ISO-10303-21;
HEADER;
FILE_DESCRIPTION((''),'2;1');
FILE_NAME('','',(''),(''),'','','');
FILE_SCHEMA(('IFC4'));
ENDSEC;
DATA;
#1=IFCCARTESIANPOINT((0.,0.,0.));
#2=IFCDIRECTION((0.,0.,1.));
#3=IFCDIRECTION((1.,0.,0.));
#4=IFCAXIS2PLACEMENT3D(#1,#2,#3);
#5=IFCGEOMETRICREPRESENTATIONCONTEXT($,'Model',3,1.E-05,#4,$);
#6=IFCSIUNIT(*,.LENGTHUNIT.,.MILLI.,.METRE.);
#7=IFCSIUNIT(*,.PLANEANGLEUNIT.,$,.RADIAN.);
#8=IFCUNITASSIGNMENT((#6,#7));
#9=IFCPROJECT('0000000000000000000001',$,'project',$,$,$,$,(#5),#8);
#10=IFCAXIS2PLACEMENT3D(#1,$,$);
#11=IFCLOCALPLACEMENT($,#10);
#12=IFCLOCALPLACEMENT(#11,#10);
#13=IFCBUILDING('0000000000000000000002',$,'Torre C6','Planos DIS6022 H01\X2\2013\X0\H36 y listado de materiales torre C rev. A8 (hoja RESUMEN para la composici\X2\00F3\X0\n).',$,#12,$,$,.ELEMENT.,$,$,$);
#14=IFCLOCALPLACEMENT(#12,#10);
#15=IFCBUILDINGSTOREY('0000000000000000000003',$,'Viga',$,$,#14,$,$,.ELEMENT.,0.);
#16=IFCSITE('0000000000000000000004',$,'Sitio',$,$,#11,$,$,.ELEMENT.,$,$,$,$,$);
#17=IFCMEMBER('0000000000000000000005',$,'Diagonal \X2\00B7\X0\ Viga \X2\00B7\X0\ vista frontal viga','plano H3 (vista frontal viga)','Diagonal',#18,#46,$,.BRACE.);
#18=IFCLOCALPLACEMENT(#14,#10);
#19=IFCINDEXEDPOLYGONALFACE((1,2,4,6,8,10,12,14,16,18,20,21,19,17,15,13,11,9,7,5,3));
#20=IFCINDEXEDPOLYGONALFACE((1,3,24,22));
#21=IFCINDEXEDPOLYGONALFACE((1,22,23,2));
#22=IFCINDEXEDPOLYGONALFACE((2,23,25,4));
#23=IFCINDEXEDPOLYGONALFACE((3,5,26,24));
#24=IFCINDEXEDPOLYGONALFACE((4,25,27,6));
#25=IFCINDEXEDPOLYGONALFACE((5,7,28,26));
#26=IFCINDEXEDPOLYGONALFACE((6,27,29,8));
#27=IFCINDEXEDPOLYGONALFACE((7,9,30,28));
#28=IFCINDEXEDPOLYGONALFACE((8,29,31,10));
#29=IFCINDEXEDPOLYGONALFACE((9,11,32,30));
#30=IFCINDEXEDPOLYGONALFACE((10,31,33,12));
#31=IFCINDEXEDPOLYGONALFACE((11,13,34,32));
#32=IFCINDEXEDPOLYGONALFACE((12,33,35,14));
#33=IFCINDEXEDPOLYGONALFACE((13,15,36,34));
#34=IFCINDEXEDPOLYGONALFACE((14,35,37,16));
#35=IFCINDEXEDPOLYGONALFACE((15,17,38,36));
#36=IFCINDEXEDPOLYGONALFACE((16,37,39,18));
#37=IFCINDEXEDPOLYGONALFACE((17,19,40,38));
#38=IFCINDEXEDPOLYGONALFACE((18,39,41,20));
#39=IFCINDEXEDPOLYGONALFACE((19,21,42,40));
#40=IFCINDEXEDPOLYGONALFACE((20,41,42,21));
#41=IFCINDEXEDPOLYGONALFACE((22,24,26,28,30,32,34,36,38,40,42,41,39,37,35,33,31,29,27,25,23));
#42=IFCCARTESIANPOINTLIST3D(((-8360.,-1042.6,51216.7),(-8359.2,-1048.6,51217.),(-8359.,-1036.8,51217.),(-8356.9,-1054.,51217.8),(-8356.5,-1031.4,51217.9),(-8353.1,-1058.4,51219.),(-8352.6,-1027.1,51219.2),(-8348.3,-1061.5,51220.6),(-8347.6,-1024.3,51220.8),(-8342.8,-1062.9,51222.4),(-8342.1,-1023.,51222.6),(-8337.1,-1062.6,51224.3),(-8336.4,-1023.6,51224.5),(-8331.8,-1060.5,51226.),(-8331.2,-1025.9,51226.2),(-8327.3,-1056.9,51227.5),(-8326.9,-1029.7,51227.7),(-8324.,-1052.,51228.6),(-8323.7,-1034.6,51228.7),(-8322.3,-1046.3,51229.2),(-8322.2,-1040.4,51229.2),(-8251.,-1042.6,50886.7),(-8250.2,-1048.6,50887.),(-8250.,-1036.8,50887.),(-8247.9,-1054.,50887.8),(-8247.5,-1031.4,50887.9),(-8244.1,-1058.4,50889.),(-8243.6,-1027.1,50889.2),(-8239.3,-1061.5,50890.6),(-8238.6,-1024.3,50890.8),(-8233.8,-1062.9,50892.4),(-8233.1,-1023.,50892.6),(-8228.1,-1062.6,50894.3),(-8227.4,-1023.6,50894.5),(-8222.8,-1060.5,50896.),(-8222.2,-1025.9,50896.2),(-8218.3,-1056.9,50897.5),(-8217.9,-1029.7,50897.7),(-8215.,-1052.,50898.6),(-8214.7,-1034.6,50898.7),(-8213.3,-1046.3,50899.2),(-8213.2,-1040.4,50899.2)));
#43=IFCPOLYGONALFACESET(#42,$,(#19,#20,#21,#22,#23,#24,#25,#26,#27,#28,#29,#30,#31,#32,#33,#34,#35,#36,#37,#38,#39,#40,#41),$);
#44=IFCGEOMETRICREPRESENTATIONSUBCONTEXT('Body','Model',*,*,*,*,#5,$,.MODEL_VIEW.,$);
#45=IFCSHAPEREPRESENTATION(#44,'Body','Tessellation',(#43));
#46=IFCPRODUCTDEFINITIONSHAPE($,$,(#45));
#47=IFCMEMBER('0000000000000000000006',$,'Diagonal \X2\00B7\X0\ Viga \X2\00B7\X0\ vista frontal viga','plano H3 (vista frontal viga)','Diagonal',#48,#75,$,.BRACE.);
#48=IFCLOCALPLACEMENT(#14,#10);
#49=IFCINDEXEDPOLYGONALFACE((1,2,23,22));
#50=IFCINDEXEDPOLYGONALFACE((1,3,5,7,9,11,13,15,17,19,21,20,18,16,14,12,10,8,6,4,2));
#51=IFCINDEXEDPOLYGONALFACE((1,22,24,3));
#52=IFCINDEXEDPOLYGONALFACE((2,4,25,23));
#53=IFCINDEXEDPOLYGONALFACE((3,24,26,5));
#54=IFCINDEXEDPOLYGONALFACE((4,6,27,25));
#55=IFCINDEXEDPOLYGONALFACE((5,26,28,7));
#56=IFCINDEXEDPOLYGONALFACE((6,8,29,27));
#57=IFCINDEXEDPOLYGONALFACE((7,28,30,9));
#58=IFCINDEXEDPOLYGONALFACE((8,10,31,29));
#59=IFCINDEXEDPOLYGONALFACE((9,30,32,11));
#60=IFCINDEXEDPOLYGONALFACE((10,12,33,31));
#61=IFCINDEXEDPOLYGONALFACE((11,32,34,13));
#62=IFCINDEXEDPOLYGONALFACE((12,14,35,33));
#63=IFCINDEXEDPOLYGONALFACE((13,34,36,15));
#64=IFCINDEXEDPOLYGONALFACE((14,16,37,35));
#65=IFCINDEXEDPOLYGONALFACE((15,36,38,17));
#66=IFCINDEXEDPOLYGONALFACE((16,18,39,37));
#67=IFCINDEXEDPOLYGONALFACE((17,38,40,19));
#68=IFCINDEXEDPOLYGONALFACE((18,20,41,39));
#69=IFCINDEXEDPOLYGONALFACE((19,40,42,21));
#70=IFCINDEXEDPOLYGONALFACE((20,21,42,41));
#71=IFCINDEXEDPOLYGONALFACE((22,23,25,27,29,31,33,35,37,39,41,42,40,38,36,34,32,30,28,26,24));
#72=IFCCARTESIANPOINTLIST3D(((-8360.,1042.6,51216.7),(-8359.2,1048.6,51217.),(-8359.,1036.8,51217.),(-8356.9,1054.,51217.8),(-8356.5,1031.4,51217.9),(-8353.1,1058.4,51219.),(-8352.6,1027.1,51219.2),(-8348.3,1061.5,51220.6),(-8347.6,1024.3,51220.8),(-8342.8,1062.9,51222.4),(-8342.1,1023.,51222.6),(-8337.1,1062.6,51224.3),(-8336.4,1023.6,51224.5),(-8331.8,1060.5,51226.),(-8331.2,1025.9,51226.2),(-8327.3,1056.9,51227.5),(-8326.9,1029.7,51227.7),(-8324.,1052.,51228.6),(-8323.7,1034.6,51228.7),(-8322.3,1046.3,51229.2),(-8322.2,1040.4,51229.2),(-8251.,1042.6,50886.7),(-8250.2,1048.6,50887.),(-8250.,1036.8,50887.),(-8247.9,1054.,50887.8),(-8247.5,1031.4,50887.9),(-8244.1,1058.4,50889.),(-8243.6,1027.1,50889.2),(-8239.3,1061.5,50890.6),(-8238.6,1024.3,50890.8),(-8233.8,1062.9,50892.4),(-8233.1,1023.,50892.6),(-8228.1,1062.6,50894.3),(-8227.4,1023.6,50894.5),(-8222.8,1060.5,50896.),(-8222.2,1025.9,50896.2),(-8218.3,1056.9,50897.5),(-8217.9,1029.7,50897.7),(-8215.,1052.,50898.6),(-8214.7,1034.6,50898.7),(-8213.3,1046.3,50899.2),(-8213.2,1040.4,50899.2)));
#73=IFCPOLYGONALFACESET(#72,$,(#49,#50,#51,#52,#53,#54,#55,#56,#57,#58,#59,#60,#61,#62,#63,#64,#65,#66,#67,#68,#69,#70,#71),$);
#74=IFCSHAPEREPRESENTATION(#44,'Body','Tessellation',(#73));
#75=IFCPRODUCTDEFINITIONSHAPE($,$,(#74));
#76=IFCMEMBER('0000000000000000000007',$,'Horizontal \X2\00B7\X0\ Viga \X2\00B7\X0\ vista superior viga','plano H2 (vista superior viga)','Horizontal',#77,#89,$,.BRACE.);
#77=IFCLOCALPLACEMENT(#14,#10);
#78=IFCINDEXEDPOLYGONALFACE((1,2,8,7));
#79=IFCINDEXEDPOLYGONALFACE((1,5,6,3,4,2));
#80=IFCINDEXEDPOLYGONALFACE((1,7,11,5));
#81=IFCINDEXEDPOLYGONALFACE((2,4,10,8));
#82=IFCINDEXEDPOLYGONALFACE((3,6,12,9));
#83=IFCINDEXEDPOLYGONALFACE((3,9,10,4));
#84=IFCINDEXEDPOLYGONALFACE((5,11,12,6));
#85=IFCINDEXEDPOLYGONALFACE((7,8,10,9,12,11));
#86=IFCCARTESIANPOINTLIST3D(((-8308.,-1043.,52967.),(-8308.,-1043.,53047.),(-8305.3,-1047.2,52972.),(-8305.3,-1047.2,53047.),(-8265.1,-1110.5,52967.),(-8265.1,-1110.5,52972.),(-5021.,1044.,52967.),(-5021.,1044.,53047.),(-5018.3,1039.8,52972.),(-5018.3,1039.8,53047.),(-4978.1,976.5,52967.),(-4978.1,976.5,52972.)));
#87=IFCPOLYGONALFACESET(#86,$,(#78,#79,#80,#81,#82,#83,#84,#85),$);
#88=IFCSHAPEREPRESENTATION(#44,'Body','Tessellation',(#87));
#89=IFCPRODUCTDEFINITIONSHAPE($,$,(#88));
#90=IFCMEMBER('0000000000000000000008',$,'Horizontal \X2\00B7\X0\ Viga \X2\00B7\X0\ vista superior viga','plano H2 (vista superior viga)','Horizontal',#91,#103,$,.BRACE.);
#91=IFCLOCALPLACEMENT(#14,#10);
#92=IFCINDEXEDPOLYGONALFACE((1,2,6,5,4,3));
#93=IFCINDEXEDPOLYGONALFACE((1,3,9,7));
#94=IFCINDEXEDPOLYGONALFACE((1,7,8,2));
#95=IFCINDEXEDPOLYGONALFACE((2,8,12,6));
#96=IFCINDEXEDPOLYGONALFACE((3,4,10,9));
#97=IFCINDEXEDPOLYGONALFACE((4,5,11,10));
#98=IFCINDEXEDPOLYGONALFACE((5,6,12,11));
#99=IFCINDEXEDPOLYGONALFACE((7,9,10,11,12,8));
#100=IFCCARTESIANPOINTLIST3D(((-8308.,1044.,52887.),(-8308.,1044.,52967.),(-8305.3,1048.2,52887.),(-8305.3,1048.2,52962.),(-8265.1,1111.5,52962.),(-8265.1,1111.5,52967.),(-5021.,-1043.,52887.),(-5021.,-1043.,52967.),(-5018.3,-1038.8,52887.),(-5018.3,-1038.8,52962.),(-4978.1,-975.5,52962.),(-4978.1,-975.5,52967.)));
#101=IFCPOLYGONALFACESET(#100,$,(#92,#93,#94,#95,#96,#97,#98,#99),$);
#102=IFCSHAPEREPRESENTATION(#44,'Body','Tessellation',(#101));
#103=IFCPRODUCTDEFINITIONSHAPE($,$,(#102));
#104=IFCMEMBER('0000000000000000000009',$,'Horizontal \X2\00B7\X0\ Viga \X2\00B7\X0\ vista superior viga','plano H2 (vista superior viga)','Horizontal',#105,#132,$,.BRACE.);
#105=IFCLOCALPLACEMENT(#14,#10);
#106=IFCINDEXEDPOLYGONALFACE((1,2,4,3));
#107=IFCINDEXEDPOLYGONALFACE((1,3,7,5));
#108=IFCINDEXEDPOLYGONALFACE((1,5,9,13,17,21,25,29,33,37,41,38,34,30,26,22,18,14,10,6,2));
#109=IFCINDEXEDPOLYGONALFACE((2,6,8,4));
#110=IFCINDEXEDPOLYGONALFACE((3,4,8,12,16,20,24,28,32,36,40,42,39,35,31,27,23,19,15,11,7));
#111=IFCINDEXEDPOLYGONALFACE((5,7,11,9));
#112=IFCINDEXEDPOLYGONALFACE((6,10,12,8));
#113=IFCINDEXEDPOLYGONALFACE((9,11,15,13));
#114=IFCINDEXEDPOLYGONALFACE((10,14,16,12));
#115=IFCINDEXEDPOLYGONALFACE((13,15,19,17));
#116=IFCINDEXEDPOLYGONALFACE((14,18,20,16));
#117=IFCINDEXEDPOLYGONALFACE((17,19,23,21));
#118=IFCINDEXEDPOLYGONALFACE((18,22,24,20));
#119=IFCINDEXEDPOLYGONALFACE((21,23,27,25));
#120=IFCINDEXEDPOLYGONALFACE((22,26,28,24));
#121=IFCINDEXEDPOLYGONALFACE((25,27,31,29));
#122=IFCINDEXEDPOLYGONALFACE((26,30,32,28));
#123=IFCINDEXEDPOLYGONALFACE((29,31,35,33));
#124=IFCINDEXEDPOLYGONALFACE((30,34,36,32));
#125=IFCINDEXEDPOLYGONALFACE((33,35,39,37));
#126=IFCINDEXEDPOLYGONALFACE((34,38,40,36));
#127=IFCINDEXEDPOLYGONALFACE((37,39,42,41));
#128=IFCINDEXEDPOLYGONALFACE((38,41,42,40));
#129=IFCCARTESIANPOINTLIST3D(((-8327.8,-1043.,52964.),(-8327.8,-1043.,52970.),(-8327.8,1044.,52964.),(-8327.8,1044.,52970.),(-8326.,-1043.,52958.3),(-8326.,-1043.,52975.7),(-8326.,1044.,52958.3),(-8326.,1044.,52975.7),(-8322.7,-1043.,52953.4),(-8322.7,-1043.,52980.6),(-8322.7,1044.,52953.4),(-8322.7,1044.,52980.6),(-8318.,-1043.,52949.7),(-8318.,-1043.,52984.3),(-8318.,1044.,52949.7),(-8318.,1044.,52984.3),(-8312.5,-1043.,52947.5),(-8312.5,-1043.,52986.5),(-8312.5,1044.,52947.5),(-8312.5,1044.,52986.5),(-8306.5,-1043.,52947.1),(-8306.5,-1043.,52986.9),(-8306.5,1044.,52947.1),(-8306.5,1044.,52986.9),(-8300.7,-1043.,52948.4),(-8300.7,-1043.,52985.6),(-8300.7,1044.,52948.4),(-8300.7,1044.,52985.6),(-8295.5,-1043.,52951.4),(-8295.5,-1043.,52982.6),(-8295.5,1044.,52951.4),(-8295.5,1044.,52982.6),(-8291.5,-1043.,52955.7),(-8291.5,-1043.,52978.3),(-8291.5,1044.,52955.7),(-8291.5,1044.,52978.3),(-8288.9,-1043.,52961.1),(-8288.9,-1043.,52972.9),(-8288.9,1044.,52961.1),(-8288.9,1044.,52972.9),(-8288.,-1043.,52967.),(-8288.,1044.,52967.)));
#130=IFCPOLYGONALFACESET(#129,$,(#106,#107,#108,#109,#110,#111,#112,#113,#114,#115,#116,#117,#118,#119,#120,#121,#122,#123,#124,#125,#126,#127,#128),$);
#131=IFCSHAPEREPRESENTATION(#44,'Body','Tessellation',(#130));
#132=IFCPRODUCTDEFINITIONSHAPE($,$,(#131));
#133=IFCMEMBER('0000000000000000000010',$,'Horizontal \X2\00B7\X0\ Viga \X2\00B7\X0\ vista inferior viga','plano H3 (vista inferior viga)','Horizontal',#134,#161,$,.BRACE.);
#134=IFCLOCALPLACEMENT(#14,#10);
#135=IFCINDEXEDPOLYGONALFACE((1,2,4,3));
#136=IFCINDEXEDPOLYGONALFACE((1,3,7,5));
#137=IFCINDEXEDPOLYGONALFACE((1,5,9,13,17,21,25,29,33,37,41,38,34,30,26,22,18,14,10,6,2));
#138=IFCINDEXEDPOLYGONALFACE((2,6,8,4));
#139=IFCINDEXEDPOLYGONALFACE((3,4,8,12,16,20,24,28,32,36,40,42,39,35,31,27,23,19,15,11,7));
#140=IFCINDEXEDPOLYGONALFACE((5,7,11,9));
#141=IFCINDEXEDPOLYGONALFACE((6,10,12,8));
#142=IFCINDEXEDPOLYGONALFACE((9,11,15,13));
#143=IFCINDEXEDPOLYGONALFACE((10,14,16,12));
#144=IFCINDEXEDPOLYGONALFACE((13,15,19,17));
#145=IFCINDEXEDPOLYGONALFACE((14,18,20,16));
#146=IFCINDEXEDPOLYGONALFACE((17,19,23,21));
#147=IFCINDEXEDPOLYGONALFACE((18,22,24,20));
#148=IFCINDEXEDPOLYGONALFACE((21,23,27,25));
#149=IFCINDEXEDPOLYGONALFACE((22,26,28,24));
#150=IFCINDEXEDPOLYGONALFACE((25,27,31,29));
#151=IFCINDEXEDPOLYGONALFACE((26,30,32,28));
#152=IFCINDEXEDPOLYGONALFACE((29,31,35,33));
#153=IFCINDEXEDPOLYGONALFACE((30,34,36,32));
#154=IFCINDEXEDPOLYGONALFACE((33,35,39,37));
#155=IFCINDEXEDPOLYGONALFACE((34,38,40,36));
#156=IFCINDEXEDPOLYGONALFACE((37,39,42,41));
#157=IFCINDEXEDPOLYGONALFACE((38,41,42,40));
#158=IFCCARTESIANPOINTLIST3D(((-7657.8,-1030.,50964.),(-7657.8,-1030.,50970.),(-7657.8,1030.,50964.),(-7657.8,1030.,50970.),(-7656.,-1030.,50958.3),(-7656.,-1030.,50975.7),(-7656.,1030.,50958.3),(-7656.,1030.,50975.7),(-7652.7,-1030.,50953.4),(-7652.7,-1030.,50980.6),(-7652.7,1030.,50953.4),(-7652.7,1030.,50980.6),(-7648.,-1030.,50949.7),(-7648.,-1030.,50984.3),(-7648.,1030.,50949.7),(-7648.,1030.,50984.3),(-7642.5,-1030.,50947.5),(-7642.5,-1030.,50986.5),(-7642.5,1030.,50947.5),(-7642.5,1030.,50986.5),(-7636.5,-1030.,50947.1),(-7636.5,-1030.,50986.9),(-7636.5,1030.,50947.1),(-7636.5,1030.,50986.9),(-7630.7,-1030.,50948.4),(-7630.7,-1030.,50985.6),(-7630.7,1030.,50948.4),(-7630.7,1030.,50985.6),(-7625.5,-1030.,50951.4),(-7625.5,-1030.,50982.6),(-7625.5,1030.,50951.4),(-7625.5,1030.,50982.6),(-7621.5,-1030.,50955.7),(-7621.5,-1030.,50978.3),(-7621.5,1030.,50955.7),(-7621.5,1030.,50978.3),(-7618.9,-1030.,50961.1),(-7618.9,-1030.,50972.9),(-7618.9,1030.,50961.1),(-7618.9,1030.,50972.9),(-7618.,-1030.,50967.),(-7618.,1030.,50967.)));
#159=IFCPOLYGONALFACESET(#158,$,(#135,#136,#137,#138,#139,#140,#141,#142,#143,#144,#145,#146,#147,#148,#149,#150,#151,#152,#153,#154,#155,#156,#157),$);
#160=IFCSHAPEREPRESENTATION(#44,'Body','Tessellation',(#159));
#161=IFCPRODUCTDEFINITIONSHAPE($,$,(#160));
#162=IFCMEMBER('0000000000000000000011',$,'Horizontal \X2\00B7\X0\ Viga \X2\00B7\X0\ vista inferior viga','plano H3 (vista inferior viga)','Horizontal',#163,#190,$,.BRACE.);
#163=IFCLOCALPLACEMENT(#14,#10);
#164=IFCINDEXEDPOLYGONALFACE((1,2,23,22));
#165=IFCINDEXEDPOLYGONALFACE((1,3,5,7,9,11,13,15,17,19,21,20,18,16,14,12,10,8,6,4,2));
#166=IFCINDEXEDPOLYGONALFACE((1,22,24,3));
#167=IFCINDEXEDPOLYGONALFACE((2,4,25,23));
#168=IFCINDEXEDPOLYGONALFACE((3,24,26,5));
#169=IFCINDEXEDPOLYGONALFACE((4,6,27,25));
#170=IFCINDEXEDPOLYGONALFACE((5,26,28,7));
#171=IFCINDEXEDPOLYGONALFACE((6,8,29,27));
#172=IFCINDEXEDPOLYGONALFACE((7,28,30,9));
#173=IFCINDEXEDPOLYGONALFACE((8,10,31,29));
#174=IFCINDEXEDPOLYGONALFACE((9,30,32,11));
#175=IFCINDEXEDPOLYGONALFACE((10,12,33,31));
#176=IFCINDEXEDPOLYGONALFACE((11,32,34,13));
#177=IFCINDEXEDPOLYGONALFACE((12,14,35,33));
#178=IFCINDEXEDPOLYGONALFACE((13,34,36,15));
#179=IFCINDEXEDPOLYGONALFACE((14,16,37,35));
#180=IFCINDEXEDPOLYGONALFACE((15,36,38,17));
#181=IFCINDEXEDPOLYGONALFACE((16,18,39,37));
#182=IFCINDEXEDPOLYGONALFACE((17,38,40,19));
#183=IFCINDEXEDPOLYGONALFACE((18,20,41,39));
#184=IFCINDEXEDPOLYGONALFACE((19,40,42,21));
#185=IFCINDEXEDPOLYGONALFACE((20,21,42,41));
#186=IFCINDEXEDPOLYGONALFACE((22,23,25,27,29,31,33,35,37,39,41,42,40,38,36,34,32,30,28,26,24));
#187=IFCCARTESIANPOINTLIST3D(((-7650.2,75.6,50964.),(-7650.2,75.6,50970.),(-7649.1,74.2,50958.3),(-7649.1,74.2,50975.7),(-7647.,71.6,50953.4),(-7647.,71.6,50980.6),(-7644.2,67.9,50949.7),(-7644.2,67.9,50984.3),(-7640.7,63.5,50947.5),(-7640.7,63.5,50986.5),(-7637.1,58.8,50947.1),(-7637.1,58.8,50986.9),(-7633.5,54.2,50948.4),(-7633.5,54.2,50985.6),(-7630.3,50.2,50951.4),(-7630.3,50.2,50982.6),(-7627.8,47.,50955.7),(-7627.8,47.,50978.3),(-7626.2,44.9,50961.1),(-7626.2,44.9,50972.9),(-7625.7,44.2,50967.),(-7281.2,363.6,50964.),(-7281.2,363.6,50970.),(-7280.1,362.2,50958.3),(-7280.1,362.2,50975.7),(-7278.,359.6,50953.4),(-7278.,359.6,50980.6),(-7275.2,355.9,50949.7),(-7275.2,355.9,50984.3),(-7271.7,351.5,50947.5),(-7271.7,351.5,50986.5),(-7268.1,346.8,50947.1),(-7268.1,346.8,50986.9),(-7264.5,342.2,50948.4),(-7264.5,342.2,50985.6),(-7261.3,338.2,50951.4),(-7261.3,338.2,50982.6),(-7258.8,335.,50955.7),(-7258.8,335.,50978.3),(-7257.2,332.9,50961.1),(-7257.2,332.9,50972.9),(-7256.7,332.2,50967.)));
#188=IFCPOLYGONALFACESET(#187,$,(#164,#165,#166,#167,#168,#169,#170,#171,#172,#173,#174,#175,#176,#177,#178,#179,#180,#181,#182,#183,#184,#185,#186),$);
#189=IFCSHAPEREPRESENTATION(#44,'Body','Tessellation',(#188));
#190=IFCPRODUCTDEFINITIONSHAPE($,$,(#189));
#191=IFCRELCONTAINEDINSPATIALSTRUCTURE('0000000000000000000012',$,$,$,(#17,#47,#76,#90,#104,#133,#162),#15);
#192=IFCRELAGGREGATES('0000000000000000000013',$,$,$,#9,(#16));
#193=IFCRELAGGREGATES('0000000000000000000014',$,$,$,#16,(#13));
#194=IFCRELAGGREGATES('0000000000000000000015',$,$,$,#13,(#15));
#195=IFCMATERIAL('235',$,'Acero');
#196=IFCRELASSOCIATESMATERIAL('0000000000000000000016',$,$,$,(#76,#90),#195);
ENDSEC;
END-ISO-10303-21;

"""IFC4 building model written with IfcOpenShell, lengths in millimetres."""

from ifc_helpers import new_model, si_unit, frame, frame_2d, origin, origin_with_axes, place, context, subcontext, project, spatial, circle, l_section, extrude, material, element, save


model = new_model("IFC4")

# Units and contexts
model_context = context("Model", 3, precision=1e-05, world=origin_with_axes())
body_context = subcontext(model_context, "Body", "Model", "MODEL_VIEW")
ifc_project = project(units=[si_unit("LENGTHUNIT", "METRE", prefix="MILLI"), si_unit("PLANEANGLEUNIT", "RADIAN")], contexts=[model_context])

# Site, building, storey
site_placement = place(None, origin())
site = spatial("IfcSite", under=ifc_project, at=site_placement, Name="Sitio", CompositionType="ELEMENT")
building_placement = place(site_placement, origin())
building = spatial("IfcBuilding", under=site, at=building_placement, Name="Torre C6", Description="Planos DIS6022 H01–H36 y listado de materiales torre C rev. A8 (hoja RESUMEN para la composición).", CompositionType="ELEMENT")
storey_placement = place(building_placement, origin())
storey = spatial("IfcBuildingStorey", under=building, at=storey_placement, Name="Viga", CompositionType="ELEMENT", Elevation=0.0)

# Members
ifc_material_1 = material(Name="235", Category="Acero")
for number, where, z_axis, x_axis, name in (
    (1, (-8232.0, -1043.0, 50893.0), (-0.313637, 0.0, 0.949543), (0.941309, 0.131406, 0.310917), "Diagonal · Viga · vista frontal viga"),
    (2, (-8232.0, 1043.0, 50893.0), (-0.313637, 0.0, 0.949543), (0.941309, -0.131406, 0.310917), "Diagonal · Viga · vista frontal viga"),
):
    element("IfcMember", number, at=place(storey_placement, frame(where, z_axis=z_axis, x_axis=x_axis)), inside=storey, Name=name, Description="plano H3 (vista frontal viga)", ObjectType="Diagonal", PredefinedType="BRACE", context=body_context, shape_type="SweptSolid", body=[
        extrude(circle(Radius=20.0), None, (0.0, 0.0, 1.0), 347.5),
    ])
for number, where, z_axis, x_axis, name in (
    (3, (-5021.0, 1044.0, 52967.0), (-0.844211, -0.536011, 0.0), (0.536011, -0.844211, 0.0), "Horizontal · Viga · vista superior viga"),
    (4, (-5021.0, -1043.0, 52967.0), (-0.844211, 0.536011, 0.0), (0.536011, 0.844211, 0.0), "Horizontal · Viga · vista superior viga"),
):
    element("IfcMember", number, at=place(storey_placement, frame(where, z_axis=z_axis, x_axis=x_axis)), inside=storey, material=ifc_material_1, Name=name, Description="plano H2 (vista superior viga)", ObjectType="Horizontal", PredefinedType="BRACE", context=body_context, shape_type="SweptSolid", body=[
        extrude(l_section(Depth=80.0, Width=80.0, Thickness=5.0, at=frame_2d((40.0, 40.0))), None, (0.0, 0.0, 1.0), 3893.6),
    ])
member_1_placement = place(storey_placement, frame((-8308.0, -1043.0, 52967.0), z_axis=(0.0, 1.0, 0.0), x_axis=(1.0, 0.0, 0.0)))
element("IfcMember", 5, at=member_1_placement, inside=storey, Name="Horizontal · Viga · vista superior viga", Description="plano H2 (vista superior viga)", ObjectType="Horizontal", PredefinedType="BRACE", context=body_context, shape_type="SweptSolid", body=[
    extrude(circle(Radius=20.0), None, (0.0, 0.0, 1.0), 2087.0),
])
member_2_placement = place(storey_placement, frame((-7638.0, 1030.0, 50967.0), z_axis=(0.0, -1.0, 0.0), x_axis=(1.0, 0.0, 0.0)))
element("IfcMember", 6, at=member_2_placement, inside=storey, Name="Horizontal · Viga · vista inferior viga", Description="plano H3 (vista inferior viga)", ObjectType="Horizontal", PredefinedType="BRACE", context=body_context, shape_type="SweptSolid", body=[
    extrude(circle(Radius=20.0), None, (0.0, 0.0, 1.0), 2060.0),
])
member_3_placement = place(storey_placement, frame((-7638.0, 60.0, 50967.0), z_axis=(0.788316, 0.615271, 0.0), x_axis=(0.615271, -0.788316, 0.0)))
element("IfcMember", 7, at=member_3_placement, inside=storey, Name="Horizontal · Viga · vista inferior viga", Description="plano H3 (vista inferior viga)", ObjectType="Horizontal", PredefinedType="BRACE", context=body_context, shape_type="SweptSolid", body=[
    extrude(circle(Radius=20.0), None, (0.0, 0.0, 1.0), 468.1),
])

save(model, "model.ifc")
